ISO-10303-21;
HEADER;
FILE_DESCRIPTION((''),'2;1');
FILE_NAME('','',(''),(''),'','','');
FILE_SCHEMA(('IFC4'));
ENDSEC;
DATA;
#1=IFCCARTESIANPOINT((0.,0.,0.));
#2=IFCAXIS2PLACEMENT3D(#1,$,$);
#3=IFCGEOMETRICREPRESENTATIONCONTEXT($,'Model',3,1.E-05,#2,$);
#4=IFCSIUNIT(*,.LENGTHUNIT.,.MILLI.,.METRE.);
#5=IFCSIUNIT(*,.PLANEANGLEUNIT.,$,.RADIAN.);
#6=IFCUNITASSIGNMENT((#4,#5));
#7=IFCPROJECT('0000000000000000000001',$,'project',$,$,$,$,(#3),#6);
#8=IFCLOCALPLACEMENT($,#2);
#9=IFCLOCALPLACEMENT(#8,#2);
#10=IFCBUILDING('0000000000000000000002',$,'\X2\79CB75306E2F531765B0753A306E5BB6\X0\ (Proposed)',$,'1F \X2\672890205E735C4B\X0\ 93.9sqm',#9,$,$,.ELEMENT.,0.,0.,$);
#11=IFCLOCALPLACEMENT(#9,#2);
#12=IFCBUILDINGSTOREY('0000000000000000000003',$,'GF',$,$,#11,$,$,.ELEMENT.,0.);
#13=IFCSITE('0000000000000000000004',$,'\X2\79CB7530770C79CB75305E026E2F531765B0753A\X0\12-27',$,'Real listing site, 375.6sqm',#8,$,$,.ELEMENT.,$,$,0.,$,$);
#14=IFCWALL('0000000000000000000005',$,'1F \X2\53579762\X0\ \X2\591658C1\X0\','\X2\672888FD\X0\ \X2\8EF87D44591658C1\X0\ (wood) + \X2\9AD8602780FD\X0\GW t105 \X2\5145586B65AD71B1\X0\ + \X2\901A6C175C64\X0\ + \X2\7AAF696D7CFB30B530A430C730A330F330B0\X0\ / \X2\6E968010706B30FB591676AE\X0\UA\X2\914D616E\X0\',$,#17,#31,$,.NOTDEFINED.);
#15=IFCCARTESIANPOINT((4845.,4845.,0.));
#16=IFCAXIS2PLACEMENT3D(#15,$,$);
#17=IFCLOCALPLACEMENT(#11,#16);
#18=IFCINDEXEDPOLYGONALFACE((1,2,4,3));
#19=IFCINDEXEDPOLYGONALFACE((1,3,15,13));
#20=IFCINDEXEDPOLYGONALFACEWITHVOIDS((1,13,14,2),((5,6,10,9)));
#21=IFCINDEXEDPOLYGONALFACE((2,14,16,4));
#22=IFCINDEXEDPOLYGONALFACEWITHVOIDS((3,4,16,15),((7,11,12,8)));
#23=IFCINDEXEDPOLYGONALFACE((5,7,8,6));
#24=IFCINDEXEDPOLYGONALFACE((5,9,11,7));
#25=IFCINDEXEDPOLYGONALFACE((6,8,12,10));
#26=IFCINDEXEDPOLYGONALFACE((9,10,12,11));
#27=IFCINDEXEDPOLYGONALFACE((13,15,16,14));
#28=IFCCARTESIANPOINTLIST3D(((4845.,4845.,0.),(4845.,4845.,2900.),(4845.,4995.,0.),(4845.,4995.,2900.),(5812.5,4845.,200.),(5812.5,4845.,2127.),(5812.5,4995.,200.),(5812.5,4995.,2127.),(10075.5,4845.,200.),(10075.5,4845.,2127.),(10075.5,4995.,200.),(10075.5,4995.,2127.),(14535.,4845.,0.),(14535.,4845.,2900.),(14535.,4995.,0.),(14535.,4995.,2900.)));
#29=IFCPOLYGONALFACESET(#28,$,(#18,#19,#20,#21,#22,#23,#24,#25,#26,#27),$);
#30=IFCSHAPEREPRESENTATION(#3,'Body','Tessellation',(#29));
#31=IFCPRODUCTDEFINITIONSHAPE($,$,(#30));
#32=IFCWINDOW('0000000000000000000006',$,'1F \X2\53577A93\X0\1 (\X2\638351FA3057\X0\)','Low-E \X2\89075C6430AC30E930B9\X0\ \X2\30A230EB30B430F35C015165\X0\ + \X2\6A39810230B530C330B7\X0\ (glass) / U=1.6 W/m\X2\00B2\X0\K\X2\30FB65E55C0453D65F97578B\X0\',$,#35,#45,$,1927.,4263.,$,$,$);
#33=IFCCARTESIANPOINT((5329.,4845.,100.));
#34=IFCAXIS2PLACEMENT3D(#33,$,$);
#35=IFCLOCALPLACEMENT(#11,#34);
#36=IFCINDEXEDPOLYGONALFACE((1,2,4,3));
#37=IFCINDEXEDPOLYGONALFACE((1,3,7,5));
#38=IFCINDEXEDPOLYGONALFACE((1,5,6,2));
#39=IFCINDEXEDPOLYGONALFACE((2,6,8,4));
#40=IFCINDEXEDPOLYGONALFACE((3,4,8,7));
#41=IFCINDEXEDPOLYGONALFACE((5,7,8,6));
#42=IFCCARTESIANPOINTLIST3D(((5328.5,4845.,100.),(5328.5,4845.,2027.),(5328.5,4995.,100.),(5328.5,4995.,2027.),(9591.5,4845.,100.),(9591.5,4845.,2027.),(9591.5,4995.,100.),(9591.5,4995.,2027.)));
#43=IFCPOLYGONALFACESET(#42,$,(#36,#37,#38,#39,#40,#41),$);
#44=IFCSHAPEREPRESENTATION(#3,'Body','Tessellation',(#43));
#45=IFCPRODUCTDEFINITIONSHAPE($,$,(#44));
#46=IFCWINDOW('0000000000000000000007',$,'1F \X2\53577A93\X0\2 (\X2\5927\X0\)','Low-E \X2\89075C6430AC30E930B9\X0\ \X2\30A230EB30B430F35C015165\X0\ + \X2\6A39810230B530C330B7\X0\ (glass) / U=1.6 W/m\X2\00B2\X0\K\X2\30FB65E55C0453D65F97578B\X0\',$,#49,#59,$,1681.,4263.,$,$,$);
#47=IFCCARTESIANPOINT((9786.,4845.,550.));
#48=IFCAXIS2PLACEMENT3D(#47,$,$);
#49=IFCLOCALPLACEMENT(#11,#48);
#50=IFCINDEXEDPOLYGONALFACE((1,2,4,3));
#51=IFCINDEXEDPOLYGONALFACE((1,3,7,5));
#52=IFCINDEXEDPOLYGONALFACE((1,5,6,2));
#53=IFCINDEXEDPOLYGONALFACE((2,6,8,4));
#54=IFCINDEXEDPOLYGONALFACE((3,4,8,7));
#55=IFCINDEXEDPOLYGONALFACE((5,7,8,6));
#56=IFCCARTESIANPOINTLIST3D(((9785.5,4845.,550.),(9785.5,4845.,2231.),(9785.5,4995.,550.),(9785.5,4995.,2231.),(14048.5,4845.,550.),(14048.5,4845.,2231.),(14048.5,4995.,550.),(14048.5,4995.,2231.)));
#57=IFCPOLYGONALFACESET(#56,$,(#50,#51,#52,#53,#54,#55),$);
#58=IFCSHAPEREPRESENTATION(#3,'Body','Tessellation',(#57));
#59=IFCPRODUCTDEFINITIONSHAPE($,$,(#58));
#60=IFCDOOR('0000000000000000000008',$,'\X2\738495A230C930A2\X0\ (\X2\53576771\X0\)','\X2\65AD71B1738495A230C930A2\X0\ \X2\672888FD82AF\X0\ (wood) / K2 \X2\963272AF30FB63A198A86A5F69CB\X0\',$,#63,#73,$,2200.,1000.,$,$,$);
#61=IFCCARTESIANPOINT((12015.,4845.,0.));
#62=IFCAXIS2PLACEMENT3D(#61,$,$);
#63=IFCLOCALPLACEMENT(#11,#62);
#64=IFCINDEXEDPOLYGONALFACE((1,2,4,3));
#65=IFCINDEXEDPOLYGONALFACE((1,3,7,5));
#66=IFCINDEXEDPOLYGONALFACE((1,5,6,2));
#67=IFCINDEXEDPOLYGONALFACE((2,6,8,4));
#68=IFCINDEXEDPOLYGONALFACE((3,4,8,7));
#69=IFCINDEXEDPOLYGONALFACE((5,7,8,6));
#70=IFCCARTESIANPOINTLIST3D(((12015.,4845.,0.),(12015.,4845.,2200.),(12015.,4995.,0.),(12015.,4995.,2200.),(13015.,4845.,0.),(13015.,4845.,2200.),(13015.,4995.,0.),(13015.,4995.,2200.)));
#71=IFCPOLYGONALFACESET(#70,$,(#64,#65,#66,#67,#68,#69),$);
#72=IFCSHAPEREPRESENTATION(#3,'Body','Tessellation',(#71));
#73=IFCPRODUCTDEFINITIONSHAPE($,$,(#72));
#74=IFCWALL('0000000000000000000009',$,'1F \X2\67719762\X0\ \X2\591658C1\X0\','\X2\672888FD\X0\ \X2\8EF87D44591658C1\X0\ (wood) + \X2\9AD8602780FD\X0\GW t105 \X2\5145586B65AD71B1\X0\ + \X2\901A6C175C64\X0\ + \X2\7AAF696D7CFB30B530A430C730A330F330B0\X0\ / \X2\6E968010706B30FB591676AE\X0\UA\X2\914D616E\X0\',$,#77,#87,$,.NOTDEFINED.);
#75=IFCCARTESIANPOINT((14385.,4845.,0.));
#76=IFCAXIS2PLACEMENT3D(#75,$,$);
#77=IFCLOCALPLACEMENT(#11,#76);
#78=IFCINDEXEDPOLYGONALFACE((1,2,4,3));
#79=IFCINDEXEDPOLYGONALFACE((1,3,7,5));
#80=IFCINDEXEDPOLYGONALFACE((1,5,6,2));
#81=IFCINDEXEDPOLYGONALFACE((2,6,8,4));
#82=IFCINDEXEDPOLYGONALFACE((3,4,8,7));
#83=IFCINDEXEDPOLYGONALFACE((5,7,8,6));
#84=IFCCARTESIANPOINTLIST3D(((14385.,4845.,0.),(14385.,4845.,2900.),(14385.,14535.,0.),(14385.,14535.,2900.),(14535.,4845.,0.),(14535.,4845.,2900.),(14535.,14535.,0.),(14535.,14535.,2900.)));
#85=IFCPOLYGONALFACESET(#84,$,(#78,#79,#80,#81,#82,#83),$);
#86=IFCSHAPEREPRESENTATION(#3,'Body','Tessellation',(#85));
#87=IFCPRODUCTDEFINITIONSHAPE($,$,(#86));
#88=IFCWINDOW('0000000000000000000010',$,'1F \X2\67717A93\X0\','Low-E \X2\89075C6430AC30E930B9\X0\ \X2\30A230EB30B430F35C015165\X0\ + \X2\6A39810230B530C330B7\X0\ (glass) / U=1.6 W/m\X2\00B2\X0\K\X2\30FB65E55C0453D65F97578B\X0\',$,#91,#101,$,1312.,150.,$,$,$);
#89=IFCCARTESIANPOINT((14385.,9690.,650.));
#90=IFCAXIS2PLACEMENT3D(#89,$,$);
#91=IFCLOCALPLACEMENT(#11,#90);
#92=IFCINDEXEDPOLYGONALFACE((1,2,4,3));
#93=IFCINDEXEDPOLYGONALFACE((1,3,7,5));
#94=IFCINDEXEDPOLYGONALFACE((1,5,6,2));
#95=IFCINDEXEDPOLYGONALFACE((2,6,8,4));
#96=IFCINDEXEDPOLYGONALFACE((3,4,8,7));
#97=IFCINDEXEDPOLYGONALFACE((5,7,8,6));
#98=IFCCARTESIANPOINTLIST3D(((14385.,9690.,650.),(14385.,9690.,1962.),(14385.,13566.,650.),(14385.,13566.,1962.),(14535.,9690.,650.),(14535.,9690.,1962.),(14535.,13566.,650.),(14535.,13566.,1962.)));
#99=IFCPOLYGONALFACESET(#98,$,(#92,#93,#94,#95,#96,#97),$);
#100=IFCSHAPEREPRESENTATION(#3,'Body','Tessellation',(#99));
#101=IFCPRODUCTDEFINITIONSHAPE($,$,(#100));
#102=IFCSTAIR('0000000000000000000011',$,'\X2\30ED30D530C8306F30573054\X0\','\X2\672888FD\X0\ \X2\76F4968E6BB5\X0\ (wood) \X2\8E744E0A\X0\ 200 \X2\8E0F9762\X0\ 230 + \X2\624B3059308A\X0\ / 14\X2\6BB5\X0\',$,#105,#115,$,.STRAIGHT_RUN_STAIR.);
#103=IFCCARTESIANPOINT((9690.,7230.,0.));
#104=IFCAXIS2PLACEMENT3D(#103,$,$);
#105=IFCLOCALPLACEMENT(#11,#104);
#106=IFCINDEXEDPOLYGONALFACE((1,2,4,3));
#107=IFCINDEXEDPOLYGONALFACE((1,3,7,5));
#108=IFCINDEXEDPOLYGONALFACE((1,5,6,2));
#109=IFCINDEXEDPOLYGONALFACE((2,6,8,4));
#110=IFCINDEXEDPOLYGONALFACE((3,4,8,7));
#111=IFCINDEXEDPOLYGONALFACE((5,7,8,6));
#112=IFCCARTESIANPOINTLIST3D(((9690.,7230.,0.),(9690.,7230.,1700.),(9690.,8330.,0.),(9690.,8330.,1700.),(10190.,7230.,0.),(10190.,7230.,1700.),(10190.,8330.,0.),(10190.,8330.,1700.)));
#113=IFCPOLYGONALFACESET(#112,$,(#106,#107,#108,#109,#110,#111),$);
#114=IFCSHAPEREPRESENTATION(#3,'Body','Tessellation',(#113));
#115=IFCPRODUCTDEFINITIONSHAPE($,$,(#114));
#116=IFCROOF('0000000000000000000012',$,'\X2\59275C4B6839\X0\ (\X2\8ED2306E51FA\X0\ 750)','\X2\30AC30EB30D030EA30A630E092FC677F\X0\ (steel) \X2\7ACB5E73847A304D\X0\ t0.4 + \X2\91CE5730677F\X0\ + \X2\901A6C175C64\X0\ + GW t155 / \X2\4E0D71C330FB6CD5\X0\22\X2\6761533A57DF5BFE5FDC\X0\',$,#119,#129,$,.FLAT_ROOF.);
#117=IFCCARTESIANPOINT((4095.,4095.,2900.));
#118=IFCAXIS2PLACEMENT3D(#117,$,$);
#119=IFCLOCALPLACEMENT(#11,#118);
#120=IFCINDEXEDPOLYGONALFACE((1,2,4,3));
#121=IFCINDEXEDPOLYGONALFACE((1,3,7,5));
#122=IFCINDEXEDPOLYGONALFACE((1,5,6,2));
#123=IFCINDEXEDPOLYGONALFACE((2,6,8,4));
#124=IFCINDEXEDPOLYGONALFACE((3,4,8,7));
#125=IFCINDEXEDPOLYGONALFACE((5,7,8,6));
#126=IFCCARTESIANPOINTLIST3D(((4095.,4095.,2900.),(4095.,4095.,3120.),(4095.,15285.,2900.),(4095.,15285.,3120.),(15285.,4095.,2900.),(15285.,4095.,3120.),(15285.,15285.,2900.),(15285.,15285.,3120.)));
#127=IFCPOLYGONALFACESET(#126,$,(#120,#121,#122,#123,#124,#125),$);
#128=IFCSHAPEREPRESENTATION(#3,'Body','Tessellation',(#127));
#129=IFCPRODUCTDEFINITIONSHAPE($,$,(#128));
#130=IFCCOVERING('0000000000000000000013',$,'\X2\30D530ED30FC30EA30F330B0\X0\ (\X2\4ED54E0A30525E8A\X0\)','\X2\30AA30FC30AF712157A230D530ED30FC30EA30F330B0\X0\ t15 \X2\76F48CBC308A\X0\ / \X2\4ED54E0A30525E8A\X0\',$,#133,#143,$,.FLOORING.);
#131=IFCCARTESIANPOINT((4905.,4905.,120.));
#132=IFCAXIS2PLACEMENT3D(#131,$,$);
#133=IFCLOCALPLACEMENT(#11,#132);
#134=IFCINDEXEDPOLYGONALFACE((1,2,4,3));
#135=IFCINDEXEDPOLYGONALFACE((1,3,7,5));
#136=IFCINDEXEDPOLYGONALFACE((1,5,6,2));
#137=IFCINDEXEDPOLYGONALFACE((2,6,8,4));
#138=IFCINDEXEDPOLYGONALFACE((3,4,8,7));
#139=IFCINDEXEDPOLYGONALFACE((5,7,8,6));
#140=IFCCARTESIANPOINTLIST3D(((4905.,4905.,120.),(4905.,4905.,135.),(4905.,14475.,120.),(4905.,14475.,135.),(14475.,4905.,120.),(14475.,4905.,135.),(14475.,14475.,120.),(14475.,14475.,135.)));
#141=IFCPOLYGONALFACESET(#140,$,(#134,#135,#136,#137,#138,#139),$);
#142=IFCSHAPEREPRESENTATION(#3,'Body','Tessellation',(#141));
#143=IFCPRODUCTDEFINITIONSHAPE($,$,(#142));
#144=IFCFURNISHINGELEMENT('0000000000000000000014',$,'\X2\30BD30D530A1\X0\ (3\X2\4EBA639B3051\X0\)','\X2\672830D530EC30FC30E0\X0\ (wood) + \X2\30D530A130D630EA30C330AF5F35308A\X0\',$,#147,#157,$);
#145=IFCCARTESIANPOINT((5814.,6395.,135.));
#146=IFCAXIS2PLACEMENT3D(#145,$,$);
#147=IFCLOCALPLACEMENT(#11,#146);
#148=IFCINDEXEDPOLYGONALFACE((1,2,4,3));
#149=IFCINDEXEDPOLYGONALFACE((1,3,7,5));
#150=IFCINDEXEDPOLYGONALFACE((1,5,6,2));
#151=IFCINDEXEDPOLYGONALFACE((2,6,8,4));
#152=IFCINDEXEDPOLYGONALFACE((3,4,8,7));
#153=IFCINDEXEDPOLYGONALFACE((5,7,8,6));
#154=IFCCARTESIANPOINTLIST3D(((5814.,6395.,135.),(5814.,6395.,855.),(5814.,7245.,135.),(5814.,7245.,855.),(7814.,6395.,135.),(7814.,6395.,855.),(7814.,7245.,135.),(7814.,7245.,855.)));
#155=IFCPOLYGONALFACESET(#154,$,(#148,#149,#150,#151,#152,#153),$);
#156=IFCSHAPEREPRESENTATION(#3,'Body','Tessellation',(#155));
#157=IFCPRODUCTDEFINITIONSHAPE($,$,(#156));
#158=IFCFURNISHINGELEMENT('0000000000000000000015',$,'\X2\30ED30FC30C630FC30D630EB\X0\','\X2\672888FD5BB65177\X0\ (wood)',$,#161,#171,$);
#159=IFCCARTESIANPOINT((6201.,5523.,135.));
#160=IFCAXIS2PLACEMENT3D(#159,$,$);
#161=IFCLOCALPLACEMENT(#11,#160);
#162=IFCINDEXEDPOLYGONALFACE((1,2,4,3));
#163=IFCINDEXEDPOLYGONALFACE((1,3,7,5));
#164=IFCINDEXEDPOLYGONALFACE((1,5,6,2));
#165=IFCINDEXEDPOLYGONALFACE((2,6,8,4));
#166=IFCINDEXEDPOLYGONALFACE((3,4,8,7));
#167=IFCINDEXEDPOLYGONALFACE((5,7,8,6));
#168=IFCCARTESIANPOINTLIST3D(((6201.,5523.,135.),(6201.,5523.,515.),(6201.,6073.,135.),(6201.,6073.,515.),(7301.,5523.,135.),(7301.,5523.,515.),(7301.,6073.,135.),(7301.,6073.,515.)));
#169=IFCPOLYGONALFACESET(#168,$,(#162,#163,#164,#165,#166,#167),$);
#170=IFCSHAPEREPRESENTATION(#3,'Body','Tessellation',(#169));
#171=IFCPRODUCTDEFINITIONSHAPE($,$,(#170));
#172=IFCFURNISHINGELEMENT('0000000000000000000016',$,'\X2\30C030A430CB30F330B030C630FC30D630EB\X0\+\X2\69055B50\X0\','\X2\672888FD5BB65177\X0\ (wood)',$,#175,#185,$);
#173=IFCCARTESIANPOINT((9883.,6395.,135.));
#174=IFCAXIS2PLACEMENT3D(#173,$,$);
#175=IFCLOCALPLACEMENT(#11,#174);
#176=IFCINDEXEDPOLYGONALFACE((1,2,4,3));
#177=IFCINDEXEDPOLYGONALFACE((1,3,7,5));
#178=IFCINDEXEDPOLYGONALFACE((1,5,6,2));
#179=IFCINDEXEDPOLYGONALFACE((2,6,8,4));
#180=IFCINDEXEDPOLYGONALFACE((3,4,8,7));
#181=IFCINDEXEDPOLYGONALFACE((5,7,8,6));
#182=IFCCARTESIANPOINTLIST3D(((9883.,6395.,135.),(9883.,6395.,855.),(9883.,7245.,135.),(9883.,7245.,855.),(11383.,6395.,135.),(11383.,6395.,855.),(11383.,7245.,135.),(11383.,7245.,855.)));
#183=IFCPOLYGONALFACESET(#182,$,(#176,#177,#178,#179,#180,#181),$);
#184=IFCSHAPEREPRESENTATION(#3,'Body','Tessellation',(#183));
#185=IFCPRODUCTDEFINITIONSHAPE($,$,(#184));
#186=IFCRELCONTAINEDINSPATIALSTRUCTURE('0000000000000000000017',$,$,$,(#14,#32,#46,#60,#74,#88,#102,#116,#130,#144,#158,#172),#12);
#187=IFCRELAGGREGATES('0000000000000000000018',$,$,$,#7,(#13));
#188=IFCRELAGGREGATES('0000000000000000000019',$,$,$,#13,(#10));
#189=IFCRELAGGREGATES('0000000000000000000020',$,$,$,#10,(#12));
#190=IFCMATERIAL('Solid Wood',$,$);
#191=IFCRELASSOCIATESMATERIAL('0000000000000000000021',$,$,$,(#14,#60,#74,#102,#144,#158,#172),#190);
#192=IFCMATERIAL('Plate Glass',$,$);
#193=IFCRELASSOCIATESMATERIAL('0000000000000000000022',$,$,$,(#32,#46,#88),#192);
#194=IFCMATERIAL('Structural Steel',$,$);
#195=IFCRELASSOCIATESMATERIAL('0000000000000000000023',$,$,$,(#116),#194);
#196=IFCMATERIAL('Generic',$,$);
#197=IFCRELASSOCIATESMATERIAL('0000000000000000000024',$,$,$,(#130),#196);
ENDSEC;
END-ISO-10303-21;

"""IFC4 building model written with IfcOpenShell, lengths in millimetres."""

from ifc_helpers import new_model, si_unit, frame, frame_2d, origin, place, context, project, spatial, rectangle, extrude, material, element, fill, save


model = new_model("IFC4")

# Units and contexts
model_context = context("Model", 3, precision=1e-05, world=origin())
ifc_project = project(units=[si_unit("LENGTHUNIT", "METRE", prefix="MILLI"), si_unit("PLANEANGLEUNIT", "RADIAN")], contexts=[model_context])

# Site, building, storey
site_placement = place(None, origin())
site = spatial("IfcSite", under=ifc_project, at=site_placement, Name="秋田県秋田市港北新町12-27", ObjectType="Real listing site, 375.6sqm", CompositionType="ELEMENT", RefElevation=0.0)
building_placement = place(site_placement, origin())
building = spatial("IfcBuilding", under=site, at=building_placement, Name="秋田港北新町の家 (Proposed)", ObjectType="1F 木造平屋 93.9sqm", CompositionType="ELEMENT", ElevationOfRefHeight=0.0, ElevationOfTerrain=0.0)
storey_placement = place(building_placement, origin())
storey = spatial("IfcBuildingStorey", under=building, at=storey_placement, Name="GF", CompositionType="ELEMENT", Elevation=0.0)

# Shared definitions
ifc_material_1 = material(Name="Solid Wood")

# Wall, openings, windows, door
wall_1_placement = place(storey_placement, frame((4845.0, 4845.0, 0.0)))
wall_1 = element("IfcWall", 1, at=wall_1_placement, inside=storey, material=ifc_material_1, Name="1F 南面 外壁", Description="木製 軸組外壁 (wood) + 高性能GW t105 充填断熱 + 通気層 + 窯業系サイディング / 準耐火・外皮UA配慮", PredefinedType="NOTDEFINED", context=model_context, shape_type="SweptSolid", body=[
    extrude(rectangle(XDim=9690.0, YDim=150.0, at=frame_2d((4845.0, 75.0))), frame((4845.0, 4845.0, 0.0)), (0.0, 0.0, 1.0), 2900.0),
])
opening_1_placement = place(storey_placement, frame((5329.0, 4845.0, 100.0)))
opening_1 = element("IfcOpeningElement", 2, at=opening_1_placement, cuts=wall_1, PredefinedType="NOTDEFINED", context=model_context, shape_type="SweptSolid", body=[
    extrude(rectangle(XDim=4263.0, YDim=150.0, at=frame_2d((2131.0, 75.0))), frame((5329.0, 4845.0, 100.0)), (0.0, 0.0, 1.0), 1927.0),
])
opening_2_placement = place(storey_placement, frame((9786.0, 4845.0, 550.0)))
opening_2 = element("IfcOpeningElement", 3, at=opening_2_placement, cuts=wall_1, PredefinedType="NOTDEFINED", context=model_context, shape_type="SweptSolid", body=[
    extrude(rectangle(XDim=4263.0, YDim=150.0, at=frame_2d((2131.0, 75.0))), frame((9786.0, 4845.0, 550.0)), (0.0, 0.0, 1.0), 1681.0),
])
opening_3_placement = place(storey_placement, frame((12015.0, 4845.0, 0.0)))
opening_3 = element("IfcOpeningElement", 4, at=opening_3_placement, cuts=wall_1, PredefinedType="NOTDEFINED", context=model_context, shape_type="SweptSolid", body=[
    extrude(rectangle(XDim=1000.0, YDim=150.0, at=frame_2d((500.0, 75.0))), frame((12015.0, 4845.0, 0.0)), (0.0, 0.0, 1.0), 2200.0),
])
ifc_material_2 = material(Name="Plate Glass")
window_1_placement = place(storey_placement, frame((5329.0, 4845.0, 100.0)))
window_1 = element("IfcWindow", 5, at=window_1_placement, inside=storey, material=ifc_material_2, Name="1F 南窓1 (掃出し)", Description="Low-E 複層ガラス アルゴン封入 + 樹脂サッシ (glass) / U=1.6 W/m²K・日射取得型", OverallHeight=1927.0, OverallWidth=4263.0, context=model_context, shape_type="SweptSolid", body=[
    extrude(rectangle(XDim=4263.0, YDim=150.0, at=frame_2d((2131.0, 75.0))), frame((5329.0, 4845.0, 100.0)), (0.0, 0.0, 1.0), 1927.0),
])
fill(opening_1, window_1)
window_2_placement = place(storey_placement, frame((9786.0, 4845.0, 550.0)))
window_2 = element("IfcWindow", 6, at=window_2_placement, inside=storey, material=ifc_material_2, Name="1F 南窓2 (大)", Description="Low-E 複層ガラス アルゴン封入 + 樹脂サッシ (glass) / U=1.6 W/m²K・日射取得型", OverallHeight=1681.0, OverallWidth=4263.0, context=model_context, shape_type="SweptSolid", body=[
    extrude(rectangle(XDim=4263.0, YDim=150.0, at=frame_2d((2131.0, 75.0))), frame((9786.0, 4845.0, 550.0)), (0.0, 0.0, 1.0), 1681.0),
])
fill(opening_2, window_2)
door_placement = place(storey_placement, frame((12015.0, 4845.0, 0.0)))
door = element("IfcDoor", 7, at=door_placement, inside=storey, material=ifc_material_1, Name="玄関ドア (南東)", Description="断熱玄関ドア 木製芯 (wood) / K2 防犯・採風機構", OverallHeight=2200.0, OverallWidth=1000.0, context=model_context, shape_type="SweptSolid", body=[
    extrude(rectangle(XDim=1000.0, YDim=150.0, at=frame_2d((500.0, 75.0))), frame((12015.0, 4845.0, 0.0)), (0.0, 0.0, 1.0), 2200.0),
])
fill(opening_3, door)

# Wall, opening, window
wall_2_placement = place(storey_placement, frame((14385.0, 4845.0, 0.0)))
wall_2 = element("IfcWall", 8, at=wall_2_placement, inside=storey, material=ifc_material_1, Name="1F 東面 外壁", Description="木製 軸組外壁 (wood) + 高性能GW t105 充填断熱 + 通気層 + 窯業系サイディング / 準耐火・外皮UA配慮", PredefinedType="NOTDEFINED", context=model_context, shape_type="SweptSolid", body=[
    extrude(rectangle(XDim=150.0, YDim=9690.0, at=frame_2d((75.0, 4845.0))), frame((14385.0, 4845.0, 0.0)), (0.0, 0.0, 1.0), 2900.0),
])
opening_4_placement = place(storey_placement, frame((14385.0, 9690.0, 650.0)))
opening_4 = element("IfcOpeningElement", 9, at=opening_4_placement, cuts=wall_2, PredefinedType="NOTDEFINED", context=model_context, shape_type="SweptSolid", body=[
    extrude(rectangle(XDim=150.0, YDim=3876.0, at=frame_2d((75.0, 1938.0))), frame((14385.0, 9690.0, 650.0)), (0.0, 0.0, 1.0), 1312.0),
])
window_3_placement = place(storey_placement, frame((14385.0, 9690.0, 650.0)))
window_3 = element("IfcWindow", 10, at=window_3_placement, inside=storey, material=ifc_material_2, Name="1F 東窓", Description="Low-E 複層ガラス アルゴン封入 + 樹脂サッシ (glass) / U=1.6 W/m²K・日射取得型", OverallHeight=1312.0, OverallWidth=150.0, context=model_context, shape_type="SweptSolid", body=[
    extrude(rectangle(XDim=150.0, YDim=3876.0, at=frame_2d((75.0, 1938.0))), frame((14385.0, 9690.0, 650.0)), (0.0, 0.0, 1.0), 1312.0),
])
fill(opening_4, window_3)

# Stair
stair_placement = place(storey_placement, frame((9690.0, 7230.0, 0.0)))
element("IfcStair", 11, at=stair_placement, inside=storey, material=ifc_material_1, Name="ロフトはしご", Description="木製 直階段 (wood) 蹴上 200 踏面 230 + 手すり / 14段", PredefinedType="STRAIGHT_RUN_STAIR", context=model_context, shape_type="SweptSolid", body=[
    extrude(rectangle(XDim=500.0, YDim=1100.0, at=frame_2d((250.0, 550.0))), frame((9690.0, 7230.0, 0.0)), (0.0, 0.0, 1.0), 1700.0),
])

# Roof
ifc_material_3 = material(Name="Structural Steel")
roof_placement = place(storey_placement, frame((4095.0, 4095.0, 2900.0)))
element("IfcRoof", 12, at=roof_placement, inside=storey, material=ifc_material_3, Name="大屋根 (軒の出 750)", Description="ガルバリウム鋼板 (steel) 立平葺き t0.4 + 野地板 + 通気層 + GW t155 / 不燃・法22条区域対応", PredefinedType="FLAT_ROOF", context=model_context, shape_type="SweptSolid", body=[
    extrude(rectangle(XDim=11190.0, YDim=11190.0, at=frame_2d((5595.0, 5595.0))), frame((4095.0, 4095.0, 2900.0)), (0.0, 0.0, 1.0), 220.0),
])

# Covering
ifc_material_4 = material(Name="Generic")
covering_placement = place(storey_placement, frame((4905.0, 4905.0, 120.0)))
element("IfcCovering", 13, at=covering_placement, inside=storey, material=ifc_material_4, Name="フローリング (仕上げ床)", Description="オーク無垢フローリング t15 直貼り / 仕上げ床", PredefinedType="FLOORING", context=model_context, shape_type="SweptSolid", body=[
    extrude(rectangle(XDim=9570.0, YDim=9570.0, at=frame_2d((4785.0, 4785.0))), frame((4905.0, 4905.0, 120.0)), (0.0, 0.0, 1.0), 15.0),
])

# Furnishing elements
furnishing_1_placement = place(storey_placement, frame((5814.0, 6395.0, 135.0)))
element("IfcFurnishingElement", 14, at=furnishing_1_placement, inside=storey, material=ifc_material_1, Name="ソファ (3人掛け)", Description="木フレーム (wood) + ファブリック張り", context=model_context, shape_type="SweptSolid", body=[
    extrude(rectangle(XDim=2000.0, YDim=850.0, at=frame_2d((1000.0, 425.0))), frame((5814.0, 6395.0, 135.0)), (0.0, 0.0, 1.0), 720.0),
])
furnishing_2_placement = place(storey_placement, frame((6201.0, 5523.0, 135.0)))
element("IfcFurnishingElement", 15, at=furnishing_2_placement, inside=storey, material=ifc_material_1, Name="ローテーブル", Description="木製家具 (wood)", context=model_context, shape_type="SweptSolid", body=[
    extrude(rectangle(XDim=1100.0, YDim=550.0, at=frame_2d((550.0, 275.0))), frame((6201.0, 5523.0, 135.0)), (0.0, 0.0, 1.0), 380.0),
])
furnishing_3_placement = place(storey_placement, frame((9883.0, 6395.0, 135.0)))
element("IfcFurnishingElement", 16, at=furnishing_3_placement, inside=storey, material=ifc_material_1, Name="ダイニングテーブル+椅子", Description="木製家具 (wood)", context=model_context, shape_type="SweptSolid", body=[
    extrude(rectangle(XDim=1500.0, YDim=850.0, at=frame_2d((750.0, 425.0))), frame((9883.0, 6395.0, 135.0)), (0.0, 0.0, 1.0), 720.0),
])

save(model, "model.ifc")
